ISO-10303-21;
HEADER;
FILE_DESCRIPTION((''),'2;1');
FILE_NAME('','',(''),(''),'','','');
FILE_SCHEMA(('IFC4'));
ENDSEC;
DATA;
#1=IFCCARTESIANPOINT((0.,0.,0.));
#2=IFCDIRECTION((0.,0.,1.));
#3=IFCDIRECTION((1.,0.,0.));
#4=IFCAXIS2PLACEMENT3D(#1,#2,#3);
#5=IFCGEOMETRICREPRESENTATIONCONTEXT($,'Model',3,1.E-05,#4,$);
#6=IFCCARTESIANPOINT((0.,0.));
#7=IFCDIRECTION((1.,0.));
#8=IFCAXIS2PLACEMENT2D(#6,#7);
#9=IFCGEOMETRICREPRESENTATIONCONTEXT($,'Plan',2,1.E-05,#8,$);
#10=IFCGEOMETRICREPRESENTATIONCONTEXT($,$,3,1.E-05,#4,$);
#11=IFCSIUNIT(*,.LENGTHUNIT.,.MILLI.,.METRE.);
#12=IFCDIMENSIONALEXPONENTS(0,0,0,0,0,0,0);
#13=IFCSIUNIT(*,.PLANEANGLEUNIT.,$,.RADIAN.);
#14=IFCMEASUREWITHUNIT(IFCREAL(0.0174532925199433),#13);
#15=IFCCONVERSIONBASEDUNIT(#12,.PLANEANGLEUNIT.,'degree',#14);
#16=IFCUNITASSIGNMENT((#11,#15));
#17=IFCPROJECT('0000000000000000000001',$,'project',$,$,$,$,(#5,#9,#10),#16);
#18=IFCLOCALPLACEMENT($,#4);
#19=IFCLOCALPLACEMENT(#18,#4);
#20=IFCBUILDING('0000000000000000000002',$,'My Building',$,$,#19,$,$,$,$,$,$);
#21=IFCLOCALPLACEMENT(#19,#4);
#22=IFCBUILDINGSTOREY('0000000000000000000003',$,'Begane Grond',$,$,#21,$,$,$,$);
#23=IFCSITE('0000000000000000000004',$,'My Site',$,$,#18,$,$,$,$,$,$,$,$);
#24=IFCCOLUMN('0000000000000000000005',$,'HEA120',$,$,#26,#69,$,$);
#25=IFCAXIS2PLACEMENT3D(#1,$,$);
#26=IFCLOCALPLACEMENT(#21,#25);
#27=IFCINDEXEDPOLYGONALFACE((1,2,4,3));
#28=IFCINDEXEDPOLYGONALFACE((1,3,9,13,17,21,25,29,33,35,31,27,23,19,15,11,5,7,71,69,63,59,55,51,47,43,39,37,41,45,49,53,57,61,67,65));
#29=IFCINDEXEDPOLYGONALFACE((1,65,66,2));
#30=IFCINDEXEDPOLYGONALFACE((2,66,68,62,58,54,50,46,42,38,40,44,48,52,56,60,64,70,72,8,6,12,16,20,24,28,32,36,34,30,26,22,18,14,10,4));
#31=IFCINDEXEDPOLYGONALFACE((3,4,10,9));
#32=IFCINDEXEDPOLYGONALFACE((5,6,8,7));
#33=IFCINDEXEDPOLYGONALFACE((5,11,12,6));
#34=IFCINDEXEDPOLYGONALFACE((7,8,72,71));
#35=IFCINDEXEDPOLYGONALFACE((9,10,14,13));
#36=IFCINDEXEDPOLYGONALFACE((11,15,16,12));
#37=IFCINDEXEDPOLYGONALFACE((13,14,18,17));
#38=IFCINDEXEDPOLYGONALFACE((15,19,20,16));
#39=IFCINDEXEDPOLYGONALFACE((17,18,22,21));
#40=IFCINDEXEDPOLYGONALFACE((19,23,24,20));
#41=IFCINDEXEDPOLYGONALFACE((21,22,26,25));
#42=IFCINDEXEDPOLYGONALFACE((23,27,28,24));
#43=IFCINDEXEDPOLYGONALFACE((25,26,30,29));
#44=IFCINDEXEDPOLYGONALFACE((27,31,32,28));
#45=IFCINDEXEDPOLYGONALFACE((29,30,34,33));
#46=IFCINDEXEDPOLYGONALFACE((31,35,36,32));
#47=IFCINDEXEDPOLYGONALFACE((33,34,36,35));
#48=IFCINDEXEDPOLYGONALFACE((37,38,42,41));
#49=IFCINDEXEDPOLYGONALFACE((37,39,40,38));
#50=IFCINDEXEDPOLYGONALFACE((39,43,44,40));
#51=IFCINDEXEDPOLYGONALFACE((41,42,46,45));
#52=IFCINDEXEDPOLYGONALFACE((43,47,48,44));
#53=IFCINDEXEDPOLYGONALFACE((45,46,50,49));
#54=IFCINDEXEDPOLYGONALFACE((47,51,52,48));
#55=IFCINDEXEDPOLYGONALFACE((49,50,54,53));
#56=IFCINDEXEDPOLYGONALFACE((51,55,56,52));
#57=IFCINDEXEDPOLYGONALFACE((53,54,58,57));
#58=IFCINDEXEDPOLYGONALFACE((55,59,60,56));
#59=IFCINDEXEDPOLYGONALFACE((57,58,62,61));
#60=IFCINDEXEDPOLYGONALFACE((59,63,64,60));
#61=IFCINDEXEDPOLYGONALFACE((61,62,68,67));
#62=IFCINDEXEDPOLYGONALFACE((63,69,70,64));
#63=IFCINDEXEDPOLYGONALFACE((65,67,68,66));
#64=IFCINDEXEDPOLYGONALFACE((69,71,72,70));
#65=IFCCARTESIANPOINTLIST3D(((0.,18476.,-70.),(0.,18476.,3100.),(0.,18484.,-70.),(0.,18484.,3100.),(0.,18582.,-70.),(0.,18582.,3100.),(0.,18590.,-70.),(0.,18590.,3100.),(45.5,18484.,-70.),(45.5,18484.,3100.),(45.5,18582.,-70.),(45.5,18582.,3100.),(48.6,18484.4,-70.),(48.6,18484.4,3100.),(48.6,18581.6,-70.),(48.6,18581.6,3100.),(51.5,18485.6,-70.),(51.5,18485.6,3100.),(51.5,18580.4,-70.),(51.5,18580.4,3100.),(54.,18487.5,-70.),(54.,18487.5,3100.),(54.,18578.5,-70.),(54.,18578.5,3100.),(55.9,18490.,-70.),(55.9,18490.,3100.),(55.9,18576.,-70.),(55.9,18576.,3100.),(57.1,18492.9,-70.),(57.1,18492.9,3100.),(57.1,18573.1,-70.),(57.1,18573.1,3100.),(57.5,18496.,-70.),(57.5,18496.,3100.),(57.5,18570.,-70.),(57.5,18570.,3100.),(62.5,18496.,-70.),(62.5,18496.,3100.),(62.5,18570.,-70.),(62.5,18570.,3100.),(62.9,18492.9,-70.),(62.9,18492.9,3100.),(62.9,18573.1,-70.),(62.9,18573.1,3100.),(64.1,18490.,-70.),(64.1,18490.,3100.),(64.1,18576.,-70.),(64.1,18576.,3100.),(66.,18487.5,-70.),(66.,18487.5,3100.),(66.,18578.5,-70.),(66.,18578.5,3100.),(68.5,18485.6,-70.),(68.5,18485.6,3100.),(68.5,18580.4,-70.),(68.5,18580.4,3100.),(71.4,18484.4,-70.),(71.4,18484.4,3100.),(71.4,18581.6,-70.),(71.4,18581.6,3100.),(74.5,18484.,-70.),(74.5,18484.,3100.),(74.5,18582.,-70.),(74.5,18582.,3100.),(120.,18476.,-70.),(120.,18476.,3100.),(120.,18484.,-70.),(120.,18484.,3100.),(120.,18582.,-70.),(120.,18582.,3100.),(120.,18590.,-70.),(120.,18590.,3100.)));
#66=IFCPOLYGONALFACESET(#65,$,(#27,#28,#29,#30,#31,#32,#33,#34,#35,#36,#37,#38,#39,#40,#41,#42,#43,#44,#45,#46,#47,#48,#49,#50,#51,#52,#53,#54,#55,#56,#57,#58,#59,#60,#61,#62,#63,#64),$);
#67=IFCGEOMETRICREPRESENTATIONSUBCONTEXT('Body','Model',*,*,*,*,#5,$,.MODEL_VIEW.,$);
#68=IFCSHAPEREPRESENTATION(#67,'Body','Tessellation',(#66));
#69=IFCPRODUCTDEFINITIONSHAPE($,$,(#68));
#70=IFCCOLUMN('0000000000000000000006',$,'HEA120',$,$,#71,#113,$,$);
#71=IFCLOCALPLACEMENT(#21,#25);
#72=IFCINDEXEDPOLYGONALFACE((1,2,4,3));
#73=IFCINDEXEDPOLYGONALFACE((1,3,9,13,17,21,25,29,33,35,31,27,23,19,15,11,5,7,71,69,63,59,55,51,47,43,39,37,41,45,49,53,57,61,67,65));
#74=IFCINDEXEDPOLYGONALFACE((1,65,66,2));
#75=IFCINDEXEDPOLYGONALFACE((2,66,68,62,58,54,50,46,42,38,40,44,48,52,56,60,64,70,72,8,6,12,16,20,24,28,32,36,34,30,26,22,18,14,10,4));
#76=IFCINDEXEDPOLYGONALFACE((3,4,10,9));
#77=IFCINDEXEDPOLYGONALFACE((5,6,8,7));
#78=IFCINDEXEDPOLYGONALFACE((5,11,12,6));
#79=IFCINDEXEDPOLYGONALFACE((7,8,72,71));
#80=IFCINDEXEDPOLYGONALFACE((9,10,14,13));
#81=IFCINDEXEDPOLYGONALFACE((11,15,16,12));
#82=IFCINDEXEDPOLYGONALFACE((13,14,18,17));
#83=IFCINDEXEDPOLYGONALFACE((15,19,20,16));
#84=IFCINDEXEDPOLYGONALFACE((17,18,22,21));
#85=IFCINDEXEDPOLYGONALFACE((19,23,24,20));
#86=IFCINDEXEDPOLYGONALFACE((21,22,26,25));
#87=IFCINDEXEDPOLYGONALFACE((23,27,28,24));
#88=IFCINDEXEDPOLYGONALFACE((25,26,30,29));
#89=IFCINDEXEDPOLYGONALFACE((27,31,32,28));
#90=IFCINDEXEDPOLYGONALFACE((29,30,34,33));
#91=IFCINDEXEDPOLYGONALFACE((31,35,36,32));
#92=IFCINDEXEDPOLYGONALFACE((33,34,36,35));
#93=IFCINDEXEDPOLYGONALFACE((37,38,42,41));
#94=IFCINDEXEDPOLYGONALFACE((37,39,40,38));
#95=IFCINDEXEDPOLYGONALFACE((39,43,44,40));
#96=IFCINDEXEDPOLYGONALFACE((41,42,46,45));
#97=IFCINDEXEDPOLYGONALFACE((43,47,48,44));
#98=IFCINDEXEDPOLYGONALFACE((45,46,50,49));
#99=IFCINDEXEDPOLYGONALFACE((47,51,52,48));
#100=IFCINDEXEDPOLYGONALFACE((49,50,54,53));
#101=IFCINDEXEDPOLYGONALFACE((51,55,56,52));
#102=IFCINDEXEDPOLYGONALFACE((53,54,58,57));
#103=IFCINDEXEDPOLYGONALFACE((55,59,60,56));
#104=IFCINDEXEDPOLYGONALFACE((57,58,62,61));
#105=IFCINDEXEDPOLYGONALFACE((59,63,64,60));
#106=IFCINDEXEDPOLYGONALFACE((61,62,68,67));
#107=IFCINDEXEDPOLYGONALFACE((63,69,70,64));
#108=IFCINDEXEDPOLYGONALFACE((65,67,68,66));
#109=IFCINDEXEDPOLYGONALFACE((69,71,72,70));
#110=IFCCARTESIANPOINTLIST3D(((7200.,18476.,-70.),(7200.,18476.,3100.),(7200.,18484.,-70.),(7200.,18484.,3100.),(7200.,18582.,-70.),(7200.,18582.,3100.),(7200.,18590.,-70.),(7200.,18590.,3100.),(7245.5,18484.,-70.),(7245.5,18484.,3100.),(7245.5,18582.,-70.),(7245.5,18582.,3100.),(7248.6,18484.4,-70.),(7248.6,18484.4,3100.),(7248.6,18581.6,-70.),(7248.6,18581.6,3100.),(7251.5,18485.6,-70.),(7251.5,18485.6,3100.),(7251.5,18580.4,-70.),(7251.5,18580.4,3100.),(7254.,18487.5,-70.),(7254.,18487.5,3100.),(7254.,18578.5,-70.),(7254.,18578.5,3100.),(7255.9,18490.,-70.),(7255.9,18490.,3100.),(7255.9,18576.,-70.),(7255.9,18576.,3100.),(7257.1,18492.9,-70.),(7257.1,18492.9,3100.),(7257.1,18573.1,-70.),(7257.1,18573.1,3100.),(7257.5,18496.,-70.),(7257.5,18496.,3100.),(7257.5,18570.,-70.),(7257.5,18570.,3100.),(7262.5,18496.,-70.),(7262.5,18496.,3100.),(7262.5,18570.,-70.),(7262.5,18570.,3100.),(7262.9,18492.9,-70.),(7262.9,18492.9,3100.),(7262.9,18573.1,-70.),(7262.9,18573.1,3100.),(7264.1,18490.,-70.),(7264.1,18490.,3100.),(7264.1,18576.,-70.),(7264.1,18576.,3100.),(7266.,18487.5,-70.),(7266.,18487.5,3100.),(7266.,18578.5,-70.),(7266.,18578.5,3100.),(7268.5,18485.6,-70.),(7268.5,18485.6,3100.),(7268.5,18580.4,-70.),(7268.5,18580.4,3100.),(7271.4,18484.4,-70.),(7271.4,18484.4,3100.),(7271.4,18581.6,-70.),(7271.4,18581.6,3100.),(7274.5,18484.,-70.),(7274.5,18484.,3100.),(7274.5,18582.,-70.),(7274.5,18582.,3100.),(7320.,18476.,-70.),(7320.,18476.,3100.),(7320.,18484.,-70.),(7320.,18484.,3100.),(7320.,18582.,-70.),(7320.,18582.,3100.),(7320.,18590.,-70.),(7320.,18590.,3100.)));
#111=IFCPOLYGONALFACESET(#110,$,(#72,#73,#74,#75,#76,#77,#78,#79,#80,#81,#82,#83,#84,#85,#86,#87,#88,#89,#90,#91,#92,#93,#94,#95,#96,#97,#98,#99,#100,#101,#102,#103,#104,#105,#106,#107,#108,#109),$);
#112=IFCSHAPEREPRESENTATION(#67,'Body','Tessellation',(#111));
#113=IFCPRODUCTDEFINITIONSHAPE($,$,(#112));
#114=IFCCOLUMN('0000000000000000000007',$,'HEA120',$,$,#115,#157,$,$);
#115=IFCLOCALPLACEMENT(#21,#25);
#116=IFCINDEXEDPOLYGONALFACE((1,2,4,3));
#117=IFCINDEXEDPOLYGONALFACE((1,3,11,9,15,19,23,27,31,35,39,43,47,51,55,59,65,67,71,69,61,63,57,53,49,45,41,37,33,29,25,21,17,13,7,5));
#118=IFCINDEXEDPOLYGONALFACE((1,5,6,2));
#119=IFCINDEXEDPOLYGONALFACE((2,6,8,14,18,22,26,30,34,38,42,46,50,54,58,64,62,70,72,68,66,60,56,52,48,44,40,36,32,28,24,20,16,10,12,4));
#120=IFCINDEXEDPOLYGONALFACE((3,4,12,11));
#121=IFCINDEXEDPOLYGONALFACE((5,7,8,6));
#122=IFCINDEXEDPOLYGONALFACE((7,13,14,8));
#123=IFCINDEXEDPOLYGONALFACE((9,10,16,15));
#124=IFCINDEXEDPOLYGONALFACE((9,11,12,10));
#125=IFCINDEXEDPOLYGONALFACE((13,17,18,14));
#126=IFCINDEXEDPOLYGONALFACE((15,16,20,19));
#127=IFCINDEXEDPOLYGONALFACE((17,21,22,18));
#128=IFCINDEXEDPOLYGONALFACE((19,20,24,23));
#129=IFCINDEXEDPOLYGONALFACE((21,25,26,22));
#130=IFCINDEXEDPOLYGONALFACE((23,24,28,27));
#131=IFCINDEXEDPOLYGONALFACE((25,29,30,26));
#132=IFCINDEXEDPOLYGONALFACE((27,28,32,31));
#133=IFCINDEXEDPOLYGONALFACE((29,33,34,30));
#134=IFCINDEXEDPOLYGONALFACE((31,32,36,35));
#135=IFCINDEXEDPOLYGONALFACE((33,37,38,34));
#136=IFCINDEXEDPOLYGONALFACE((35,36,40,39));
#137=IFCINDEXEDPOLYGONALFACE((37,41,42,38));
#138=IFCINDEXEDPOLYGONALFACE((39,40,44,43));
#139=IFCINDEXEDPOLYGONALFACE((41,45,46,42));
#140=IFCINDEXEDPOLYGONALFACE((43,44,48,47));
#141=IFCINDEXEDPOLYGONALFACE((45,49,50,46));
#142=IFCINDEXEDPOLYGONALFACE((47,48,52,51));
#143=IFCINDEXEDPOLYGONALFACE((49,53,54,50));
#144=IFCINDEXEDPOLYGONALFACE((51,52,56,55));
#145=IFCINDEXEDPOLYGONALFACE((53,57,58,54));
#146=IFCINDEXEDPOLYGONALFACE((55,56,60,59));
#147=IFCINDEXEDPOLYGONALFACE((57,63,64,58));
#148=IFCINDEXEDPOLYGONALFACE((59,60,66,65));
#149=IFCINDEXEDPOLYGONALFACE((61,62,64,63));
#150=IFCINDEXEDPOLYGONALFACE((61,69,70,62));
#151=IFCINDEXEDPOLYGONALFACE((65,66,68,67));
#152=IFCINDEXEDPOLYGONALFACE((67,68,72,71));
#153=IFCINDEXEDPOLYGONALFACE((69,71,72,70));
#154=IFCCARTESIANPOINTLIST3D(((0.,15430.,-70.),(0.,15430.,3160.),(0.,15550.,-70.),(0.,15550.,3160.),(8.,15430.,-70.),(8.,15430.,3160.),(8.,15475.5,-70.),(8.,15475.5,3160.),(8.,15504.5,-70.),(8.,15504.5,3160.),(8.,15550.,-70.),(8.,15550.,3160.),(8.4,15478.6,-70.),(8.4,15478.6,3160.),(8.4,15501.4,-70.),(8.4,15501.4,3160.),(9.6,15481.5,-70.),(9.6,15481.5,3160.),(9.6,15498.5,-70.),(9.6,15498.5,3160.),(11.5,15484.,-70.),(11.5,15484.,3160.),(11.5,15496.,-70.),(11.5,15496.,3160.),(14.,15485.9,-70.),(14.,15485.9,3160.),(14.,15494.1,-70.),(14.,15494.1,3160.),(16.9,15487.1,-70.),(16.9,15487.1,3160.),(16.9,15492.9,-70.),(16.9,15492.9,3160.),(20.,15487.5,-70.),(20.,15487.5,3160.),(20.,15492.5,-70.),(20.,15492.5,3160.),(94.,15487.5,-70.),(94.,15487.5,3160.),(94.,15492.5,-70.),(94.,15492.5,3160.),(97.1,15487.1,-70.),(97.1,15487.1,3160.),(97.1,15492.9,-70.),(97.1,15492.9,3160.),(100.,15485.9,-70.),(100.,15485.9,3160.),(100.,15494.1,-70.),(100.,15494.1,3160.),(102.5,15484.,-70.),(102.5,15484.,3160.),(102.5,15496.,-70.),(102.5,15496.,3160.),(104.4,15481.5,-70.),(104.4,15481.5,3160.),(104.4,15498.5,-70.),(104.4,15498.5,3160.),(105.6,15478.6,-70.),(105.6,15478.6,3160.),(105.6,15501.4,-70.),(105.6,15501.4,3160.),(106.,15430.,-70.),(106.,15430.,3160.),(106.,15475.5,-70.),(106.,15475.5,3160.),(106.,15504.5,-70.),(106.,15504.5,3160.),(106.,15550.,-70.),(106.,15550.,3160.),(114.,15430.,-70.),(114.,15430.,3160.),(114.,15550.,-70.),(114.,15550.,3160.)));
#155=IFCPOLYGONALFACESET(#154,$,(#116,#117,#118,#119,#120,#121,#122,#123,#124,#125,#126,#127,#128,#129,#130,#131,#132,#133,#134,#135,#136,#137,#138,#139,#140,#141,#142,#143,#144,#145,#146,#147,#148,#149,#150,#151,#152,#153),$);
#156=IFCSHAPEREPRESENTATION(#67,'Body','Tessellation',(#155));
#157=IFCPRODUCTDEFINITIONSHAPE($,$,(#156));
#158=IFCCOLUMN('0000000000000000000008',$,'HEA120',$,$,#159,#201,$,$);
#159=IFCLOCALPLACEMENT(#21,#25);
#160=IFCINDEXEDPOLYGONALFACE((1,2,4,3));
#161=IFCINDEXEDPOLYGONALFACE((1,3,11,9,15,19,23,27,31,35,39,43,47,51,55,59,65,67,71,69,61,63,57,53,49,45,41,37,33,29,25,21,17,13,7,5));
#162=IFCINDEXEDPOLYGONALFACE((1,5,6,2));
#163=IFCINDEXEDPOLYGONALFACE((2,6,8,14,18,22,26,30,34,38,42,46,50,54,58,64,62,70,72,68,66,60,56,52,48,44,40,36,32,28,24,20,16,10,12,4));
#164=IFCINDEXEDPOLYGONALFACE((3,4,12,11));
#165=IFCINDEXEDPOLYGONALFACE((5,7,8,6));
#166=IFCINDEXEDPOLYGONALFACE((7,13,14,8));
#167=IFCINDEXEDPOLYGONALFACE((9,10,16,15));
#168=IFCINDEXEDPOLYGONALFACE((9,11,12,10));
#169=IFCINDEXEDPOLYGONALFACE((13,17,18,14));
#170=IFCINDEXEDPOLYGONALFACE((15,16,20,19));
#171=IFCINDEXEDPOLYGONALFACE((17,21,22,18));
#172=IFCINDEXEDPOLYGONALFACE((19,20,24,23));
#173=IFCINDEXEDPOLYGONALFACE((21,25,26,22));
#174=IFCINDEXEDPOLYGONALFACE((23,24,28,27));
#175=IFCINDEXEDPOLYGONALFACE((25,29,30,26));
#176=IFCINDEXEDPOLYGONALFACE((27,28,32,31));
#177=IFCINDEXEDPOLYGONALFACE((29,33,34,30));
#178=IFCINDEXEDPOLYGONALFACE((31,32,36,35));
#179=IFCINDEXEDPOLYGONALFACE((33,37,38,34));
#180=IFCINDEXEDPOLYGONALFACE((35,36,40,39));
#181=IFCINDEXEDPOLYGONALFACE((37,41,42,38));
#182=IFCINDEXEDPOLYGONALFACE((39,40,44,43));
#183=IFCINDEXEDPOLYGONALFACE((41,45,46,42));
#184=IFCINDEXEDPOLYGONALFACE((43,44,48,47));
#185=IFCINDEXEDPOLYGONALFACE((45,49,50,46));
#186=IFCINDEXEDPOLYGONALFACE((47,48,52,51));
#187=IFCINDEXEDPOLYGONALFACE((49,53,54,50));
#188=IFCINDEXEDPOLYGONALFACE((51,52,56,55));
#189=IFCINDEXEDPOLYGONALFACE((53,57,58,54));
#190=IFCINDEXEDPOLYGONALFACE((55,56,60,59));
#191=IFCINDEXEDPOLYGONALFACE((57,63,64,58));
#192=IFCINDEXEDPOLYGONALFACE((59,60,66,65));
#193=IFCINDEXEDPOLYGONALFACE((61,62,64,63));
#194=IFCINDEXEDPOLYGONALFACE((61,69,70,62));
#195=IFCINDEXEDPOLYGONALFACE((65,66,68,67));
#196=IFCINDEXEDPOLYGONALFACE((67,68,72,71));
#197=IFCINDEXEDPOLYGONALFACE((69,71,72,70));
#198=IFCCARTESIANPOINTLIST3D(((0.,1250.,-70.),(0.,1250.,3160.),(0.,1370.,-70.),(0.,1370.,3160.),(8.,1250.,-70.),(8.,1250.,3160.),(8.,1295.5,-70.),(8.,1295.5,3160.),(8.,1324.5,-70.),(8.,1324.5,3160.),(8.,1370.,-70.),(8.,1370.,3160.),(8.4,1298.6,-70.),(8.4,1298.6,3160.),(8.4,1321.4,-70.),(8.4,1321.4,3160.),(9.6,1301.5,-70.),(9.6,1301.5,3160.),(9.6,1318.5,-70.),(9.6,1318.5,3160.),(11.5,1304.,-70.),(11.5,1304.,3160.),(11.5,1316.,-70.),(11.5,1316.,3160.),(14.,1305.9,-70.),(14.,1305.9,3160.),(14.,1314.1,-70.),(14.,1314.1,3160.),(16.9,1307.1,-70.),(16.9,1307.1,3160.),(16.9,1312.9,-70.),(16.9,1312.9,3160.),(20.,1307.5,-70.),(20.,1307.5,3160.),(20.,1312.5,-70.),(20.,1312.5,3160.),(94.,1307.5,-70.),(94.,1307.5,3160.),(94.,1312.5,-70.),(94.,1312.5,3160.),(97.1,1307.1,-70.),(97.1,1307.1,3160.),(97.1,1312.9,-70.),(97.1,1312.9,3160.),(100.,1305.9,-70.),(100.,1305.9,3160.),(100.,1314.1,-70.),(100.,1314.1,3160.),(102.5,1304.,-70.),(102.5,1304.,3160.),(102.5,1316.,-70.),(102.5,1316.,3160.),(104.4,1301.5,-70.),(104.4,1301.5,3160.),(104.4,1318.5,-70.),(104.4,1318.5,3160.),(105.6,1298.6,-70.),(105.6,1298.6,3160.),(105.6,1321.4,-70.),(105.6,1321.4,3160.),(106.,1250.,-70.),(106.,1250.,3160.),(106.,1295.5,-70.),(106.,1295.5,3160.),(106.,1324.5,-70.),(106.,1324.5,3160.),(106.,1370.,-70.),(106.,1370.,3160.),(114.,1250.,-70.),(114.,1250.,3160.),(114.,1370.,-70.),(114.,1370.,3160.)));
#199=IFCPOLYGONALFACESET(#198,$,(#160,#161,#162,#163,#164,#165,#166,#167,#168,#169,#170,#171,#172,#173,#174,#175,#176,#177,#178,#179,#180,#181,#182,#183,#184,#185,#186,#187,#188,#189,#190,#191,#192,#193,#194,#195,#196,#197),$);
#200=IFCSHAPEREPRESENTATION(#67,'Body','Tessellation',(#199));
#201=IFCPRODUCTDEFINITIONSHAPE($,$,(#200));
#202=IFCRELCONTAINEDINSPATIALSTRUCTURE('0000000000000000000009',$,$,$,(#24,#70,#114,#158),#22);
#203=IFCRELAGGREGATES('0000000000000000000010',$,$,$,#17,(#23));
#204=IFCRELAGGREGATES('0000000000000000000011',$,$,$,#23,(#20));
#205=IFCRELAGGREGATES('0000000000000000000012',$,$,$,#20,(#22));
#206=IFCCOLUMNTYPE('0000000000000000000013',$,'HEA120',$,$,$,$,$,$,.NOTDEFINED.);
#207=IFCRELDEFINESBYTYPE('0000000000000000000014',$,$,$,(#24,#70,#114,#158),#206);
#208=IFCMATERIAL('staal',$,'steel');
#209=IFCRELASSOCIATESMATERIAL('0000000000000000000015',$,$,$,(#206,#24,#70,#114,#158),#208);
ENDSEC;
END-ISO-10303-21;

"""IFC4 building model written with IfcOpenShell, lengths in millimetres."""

from ifc_helpers import new_model, entity, si_unit, converted_unit, frame, origin_with_axes, origin_2d_with_axis, place, context, subcontext, project, spatial, i_section, extrude, material, material_profile, profile_set, profile_usage, type_object, element, save


model = new_model("IFC4")

# Units and contexts
model_context = context("Model", 3, precision=1e-05, world=origin_with_axes())
plan_context = context("Plan", 2, precision=1e-05, world=origin_2d_with_axis())
context_of_model = context(None, 3, precision=1e-05, world=origin_with_axes())
body_context = subcontext(model_context, "Body", "Model", "MODEL_VIEW")
ifc_project = project(units=[si_unit("LENGTHUNIT", "METRE", prefix="MILLI"), converted_unit("PLANEANGLEUNIT", "degree", entity("IfcReal", 0.0174532925199433), si_unit("PLANEANGLEUNIT", "RADIAN"), dimensions=[0, 0, 0, 0, 0, 0, 0])], contexts=[model_context, plan_context, context_of_model])

# Site, building, storey
site_placement = place(None, origin_with_axes())
site = spatial("IfcSite", under=ifc_project, at=site_placement, Name="My Site")
building_placement = place(site_placement, origin_with_axes())
building = spatial("IfcBuilding", under=site, at=building_placement, Name="My Building")
storey_placement = place(building_placement, origin_with_axes())
storey = spatial("IfcBuildingStorey", under=building, at=storey_placement, Name="Begane Grond")

# Columns
ifc_material = material(Name="staal", Category="steel")
ifc_material_profile_1 = material_profile(ifc_material, i_section(OverallWidth=120.0, OverallDepth=114.0, WebThickness=5.0, FlangeThickness=8.0, FilletRadius=12.0))
ifc_profile_set_1 = profile_set([ifc_material_profile_1], Name="HEA120")
ifc_profile_usage_1 = profile_usage(ifc_profile_set_1, cardinal=8)
column_type_1 = type_object("IfcColumnType", Name="HEA120", PredefinedType="NOTDEFINED", material=ifc_profile_set_1)
column_1_placement = place(storey_placement, frame((60.0, 18590.0, -70.0), z_axis=(0.0, 0.0, 1.0), x_axis=(1.0, 0.0, 0.0)))
element("IfcColumn", 1, at=column_1_placement, inside=storey, type_object=column_type_1, material=ifc_profile_usage_1, Name="HEA120", context=body_context, shape_type="SweptSolid", body=[
    extrude(i_section(OverallWidth=120.0, OverallDepth=114.0, WebThickness=5.0, FlangeThickness=8.0, FilletRadius=12.0), frame((0.0, -57.0, 0.0), z_axis=(0.0, 0.0, 1.0), x_axis=(1.0, 0.0, 0.0)), (0.0, 0.0, 1.0), 3170.0),
])
ifc_profile_usage_2 = profile_usage(ifc_profile_set_1, cardinal=8)
column_2_placement = place(storey_placement, frame((7260.0, 18590.0, -70.0), z_axis=(0.0, 0.0, 1.0), x_axis=(1.0, 0.0, 0.0)))
element("IfcColumn", 2, at=column_2_placement, inside=storey, type_object=column_type_1, material=ifc_profile_usage_2, Name="HEA120", context=body_context, shape_type="SweptSolid", body=[
    extrude(i_section(OverallWidth=120.0, OverallDepth=114.0, WebThickness=5.0, FlangeThickness=8.0, FilletRadius=12.0), frame((0.0, -57.0, 0.0), z_axis=(0.0, 0.0, 1.0), x_axis=(1.0, 0.0, 0.0)), (0.0, 0.0, 1.0), 3170.0),
])
ifc_profile_usage_3 = profile_usage(ifc_profile_set_1)
column_3_placement = place(storey_placement, frame((57.0, 15490.0, -70.0), z_axis=(0.0, 0.0, 1.0), x_axis=(0.0, 1.0, 0.0)))
element("IfcColumn", 3, at=column_3_placement, inside=storey, type_object=column_type_1, material=ifc_profile_usage_3, Name="HEA120", context=body_context, shape_type="SweptSolid", body=[
    extrude(i_section(OverallWidth=120.0, OverallDepth=114.0, WebThickness=5.0, FlangeThickness=8.0, FilletRadius=12.0), origin_with_axes(), (0.0, 0.0, 1.0), 3230.0),
])
ifc_profile_usage_4 = profile_usage(ifc_profile_set_1)
column_4_placement = place(storey_placement, frame((57.0, 1310.0, -70.0), z_axis=(0.0, 0.0, 1.0), x_axis=(0.0, 1.0, 0.0)))
element("IfcColumn", 4, at=column_4_placement, inside=storey, type_object=column_type_1, material=ifc_profile_usage_4, Name="HEA120", context=body_context, shape_type="SweptSolid", body=[
    extrude(i_section(OverallWidth=120.0, OverallDepth=114.0, WebThickness=5.0, FlangeThickness=8.0, FilletRadius=12.0), origin_with_axes(), (0.0, 0.0, 1.0), 3230.0),
])

save(model, "model.ifc")
